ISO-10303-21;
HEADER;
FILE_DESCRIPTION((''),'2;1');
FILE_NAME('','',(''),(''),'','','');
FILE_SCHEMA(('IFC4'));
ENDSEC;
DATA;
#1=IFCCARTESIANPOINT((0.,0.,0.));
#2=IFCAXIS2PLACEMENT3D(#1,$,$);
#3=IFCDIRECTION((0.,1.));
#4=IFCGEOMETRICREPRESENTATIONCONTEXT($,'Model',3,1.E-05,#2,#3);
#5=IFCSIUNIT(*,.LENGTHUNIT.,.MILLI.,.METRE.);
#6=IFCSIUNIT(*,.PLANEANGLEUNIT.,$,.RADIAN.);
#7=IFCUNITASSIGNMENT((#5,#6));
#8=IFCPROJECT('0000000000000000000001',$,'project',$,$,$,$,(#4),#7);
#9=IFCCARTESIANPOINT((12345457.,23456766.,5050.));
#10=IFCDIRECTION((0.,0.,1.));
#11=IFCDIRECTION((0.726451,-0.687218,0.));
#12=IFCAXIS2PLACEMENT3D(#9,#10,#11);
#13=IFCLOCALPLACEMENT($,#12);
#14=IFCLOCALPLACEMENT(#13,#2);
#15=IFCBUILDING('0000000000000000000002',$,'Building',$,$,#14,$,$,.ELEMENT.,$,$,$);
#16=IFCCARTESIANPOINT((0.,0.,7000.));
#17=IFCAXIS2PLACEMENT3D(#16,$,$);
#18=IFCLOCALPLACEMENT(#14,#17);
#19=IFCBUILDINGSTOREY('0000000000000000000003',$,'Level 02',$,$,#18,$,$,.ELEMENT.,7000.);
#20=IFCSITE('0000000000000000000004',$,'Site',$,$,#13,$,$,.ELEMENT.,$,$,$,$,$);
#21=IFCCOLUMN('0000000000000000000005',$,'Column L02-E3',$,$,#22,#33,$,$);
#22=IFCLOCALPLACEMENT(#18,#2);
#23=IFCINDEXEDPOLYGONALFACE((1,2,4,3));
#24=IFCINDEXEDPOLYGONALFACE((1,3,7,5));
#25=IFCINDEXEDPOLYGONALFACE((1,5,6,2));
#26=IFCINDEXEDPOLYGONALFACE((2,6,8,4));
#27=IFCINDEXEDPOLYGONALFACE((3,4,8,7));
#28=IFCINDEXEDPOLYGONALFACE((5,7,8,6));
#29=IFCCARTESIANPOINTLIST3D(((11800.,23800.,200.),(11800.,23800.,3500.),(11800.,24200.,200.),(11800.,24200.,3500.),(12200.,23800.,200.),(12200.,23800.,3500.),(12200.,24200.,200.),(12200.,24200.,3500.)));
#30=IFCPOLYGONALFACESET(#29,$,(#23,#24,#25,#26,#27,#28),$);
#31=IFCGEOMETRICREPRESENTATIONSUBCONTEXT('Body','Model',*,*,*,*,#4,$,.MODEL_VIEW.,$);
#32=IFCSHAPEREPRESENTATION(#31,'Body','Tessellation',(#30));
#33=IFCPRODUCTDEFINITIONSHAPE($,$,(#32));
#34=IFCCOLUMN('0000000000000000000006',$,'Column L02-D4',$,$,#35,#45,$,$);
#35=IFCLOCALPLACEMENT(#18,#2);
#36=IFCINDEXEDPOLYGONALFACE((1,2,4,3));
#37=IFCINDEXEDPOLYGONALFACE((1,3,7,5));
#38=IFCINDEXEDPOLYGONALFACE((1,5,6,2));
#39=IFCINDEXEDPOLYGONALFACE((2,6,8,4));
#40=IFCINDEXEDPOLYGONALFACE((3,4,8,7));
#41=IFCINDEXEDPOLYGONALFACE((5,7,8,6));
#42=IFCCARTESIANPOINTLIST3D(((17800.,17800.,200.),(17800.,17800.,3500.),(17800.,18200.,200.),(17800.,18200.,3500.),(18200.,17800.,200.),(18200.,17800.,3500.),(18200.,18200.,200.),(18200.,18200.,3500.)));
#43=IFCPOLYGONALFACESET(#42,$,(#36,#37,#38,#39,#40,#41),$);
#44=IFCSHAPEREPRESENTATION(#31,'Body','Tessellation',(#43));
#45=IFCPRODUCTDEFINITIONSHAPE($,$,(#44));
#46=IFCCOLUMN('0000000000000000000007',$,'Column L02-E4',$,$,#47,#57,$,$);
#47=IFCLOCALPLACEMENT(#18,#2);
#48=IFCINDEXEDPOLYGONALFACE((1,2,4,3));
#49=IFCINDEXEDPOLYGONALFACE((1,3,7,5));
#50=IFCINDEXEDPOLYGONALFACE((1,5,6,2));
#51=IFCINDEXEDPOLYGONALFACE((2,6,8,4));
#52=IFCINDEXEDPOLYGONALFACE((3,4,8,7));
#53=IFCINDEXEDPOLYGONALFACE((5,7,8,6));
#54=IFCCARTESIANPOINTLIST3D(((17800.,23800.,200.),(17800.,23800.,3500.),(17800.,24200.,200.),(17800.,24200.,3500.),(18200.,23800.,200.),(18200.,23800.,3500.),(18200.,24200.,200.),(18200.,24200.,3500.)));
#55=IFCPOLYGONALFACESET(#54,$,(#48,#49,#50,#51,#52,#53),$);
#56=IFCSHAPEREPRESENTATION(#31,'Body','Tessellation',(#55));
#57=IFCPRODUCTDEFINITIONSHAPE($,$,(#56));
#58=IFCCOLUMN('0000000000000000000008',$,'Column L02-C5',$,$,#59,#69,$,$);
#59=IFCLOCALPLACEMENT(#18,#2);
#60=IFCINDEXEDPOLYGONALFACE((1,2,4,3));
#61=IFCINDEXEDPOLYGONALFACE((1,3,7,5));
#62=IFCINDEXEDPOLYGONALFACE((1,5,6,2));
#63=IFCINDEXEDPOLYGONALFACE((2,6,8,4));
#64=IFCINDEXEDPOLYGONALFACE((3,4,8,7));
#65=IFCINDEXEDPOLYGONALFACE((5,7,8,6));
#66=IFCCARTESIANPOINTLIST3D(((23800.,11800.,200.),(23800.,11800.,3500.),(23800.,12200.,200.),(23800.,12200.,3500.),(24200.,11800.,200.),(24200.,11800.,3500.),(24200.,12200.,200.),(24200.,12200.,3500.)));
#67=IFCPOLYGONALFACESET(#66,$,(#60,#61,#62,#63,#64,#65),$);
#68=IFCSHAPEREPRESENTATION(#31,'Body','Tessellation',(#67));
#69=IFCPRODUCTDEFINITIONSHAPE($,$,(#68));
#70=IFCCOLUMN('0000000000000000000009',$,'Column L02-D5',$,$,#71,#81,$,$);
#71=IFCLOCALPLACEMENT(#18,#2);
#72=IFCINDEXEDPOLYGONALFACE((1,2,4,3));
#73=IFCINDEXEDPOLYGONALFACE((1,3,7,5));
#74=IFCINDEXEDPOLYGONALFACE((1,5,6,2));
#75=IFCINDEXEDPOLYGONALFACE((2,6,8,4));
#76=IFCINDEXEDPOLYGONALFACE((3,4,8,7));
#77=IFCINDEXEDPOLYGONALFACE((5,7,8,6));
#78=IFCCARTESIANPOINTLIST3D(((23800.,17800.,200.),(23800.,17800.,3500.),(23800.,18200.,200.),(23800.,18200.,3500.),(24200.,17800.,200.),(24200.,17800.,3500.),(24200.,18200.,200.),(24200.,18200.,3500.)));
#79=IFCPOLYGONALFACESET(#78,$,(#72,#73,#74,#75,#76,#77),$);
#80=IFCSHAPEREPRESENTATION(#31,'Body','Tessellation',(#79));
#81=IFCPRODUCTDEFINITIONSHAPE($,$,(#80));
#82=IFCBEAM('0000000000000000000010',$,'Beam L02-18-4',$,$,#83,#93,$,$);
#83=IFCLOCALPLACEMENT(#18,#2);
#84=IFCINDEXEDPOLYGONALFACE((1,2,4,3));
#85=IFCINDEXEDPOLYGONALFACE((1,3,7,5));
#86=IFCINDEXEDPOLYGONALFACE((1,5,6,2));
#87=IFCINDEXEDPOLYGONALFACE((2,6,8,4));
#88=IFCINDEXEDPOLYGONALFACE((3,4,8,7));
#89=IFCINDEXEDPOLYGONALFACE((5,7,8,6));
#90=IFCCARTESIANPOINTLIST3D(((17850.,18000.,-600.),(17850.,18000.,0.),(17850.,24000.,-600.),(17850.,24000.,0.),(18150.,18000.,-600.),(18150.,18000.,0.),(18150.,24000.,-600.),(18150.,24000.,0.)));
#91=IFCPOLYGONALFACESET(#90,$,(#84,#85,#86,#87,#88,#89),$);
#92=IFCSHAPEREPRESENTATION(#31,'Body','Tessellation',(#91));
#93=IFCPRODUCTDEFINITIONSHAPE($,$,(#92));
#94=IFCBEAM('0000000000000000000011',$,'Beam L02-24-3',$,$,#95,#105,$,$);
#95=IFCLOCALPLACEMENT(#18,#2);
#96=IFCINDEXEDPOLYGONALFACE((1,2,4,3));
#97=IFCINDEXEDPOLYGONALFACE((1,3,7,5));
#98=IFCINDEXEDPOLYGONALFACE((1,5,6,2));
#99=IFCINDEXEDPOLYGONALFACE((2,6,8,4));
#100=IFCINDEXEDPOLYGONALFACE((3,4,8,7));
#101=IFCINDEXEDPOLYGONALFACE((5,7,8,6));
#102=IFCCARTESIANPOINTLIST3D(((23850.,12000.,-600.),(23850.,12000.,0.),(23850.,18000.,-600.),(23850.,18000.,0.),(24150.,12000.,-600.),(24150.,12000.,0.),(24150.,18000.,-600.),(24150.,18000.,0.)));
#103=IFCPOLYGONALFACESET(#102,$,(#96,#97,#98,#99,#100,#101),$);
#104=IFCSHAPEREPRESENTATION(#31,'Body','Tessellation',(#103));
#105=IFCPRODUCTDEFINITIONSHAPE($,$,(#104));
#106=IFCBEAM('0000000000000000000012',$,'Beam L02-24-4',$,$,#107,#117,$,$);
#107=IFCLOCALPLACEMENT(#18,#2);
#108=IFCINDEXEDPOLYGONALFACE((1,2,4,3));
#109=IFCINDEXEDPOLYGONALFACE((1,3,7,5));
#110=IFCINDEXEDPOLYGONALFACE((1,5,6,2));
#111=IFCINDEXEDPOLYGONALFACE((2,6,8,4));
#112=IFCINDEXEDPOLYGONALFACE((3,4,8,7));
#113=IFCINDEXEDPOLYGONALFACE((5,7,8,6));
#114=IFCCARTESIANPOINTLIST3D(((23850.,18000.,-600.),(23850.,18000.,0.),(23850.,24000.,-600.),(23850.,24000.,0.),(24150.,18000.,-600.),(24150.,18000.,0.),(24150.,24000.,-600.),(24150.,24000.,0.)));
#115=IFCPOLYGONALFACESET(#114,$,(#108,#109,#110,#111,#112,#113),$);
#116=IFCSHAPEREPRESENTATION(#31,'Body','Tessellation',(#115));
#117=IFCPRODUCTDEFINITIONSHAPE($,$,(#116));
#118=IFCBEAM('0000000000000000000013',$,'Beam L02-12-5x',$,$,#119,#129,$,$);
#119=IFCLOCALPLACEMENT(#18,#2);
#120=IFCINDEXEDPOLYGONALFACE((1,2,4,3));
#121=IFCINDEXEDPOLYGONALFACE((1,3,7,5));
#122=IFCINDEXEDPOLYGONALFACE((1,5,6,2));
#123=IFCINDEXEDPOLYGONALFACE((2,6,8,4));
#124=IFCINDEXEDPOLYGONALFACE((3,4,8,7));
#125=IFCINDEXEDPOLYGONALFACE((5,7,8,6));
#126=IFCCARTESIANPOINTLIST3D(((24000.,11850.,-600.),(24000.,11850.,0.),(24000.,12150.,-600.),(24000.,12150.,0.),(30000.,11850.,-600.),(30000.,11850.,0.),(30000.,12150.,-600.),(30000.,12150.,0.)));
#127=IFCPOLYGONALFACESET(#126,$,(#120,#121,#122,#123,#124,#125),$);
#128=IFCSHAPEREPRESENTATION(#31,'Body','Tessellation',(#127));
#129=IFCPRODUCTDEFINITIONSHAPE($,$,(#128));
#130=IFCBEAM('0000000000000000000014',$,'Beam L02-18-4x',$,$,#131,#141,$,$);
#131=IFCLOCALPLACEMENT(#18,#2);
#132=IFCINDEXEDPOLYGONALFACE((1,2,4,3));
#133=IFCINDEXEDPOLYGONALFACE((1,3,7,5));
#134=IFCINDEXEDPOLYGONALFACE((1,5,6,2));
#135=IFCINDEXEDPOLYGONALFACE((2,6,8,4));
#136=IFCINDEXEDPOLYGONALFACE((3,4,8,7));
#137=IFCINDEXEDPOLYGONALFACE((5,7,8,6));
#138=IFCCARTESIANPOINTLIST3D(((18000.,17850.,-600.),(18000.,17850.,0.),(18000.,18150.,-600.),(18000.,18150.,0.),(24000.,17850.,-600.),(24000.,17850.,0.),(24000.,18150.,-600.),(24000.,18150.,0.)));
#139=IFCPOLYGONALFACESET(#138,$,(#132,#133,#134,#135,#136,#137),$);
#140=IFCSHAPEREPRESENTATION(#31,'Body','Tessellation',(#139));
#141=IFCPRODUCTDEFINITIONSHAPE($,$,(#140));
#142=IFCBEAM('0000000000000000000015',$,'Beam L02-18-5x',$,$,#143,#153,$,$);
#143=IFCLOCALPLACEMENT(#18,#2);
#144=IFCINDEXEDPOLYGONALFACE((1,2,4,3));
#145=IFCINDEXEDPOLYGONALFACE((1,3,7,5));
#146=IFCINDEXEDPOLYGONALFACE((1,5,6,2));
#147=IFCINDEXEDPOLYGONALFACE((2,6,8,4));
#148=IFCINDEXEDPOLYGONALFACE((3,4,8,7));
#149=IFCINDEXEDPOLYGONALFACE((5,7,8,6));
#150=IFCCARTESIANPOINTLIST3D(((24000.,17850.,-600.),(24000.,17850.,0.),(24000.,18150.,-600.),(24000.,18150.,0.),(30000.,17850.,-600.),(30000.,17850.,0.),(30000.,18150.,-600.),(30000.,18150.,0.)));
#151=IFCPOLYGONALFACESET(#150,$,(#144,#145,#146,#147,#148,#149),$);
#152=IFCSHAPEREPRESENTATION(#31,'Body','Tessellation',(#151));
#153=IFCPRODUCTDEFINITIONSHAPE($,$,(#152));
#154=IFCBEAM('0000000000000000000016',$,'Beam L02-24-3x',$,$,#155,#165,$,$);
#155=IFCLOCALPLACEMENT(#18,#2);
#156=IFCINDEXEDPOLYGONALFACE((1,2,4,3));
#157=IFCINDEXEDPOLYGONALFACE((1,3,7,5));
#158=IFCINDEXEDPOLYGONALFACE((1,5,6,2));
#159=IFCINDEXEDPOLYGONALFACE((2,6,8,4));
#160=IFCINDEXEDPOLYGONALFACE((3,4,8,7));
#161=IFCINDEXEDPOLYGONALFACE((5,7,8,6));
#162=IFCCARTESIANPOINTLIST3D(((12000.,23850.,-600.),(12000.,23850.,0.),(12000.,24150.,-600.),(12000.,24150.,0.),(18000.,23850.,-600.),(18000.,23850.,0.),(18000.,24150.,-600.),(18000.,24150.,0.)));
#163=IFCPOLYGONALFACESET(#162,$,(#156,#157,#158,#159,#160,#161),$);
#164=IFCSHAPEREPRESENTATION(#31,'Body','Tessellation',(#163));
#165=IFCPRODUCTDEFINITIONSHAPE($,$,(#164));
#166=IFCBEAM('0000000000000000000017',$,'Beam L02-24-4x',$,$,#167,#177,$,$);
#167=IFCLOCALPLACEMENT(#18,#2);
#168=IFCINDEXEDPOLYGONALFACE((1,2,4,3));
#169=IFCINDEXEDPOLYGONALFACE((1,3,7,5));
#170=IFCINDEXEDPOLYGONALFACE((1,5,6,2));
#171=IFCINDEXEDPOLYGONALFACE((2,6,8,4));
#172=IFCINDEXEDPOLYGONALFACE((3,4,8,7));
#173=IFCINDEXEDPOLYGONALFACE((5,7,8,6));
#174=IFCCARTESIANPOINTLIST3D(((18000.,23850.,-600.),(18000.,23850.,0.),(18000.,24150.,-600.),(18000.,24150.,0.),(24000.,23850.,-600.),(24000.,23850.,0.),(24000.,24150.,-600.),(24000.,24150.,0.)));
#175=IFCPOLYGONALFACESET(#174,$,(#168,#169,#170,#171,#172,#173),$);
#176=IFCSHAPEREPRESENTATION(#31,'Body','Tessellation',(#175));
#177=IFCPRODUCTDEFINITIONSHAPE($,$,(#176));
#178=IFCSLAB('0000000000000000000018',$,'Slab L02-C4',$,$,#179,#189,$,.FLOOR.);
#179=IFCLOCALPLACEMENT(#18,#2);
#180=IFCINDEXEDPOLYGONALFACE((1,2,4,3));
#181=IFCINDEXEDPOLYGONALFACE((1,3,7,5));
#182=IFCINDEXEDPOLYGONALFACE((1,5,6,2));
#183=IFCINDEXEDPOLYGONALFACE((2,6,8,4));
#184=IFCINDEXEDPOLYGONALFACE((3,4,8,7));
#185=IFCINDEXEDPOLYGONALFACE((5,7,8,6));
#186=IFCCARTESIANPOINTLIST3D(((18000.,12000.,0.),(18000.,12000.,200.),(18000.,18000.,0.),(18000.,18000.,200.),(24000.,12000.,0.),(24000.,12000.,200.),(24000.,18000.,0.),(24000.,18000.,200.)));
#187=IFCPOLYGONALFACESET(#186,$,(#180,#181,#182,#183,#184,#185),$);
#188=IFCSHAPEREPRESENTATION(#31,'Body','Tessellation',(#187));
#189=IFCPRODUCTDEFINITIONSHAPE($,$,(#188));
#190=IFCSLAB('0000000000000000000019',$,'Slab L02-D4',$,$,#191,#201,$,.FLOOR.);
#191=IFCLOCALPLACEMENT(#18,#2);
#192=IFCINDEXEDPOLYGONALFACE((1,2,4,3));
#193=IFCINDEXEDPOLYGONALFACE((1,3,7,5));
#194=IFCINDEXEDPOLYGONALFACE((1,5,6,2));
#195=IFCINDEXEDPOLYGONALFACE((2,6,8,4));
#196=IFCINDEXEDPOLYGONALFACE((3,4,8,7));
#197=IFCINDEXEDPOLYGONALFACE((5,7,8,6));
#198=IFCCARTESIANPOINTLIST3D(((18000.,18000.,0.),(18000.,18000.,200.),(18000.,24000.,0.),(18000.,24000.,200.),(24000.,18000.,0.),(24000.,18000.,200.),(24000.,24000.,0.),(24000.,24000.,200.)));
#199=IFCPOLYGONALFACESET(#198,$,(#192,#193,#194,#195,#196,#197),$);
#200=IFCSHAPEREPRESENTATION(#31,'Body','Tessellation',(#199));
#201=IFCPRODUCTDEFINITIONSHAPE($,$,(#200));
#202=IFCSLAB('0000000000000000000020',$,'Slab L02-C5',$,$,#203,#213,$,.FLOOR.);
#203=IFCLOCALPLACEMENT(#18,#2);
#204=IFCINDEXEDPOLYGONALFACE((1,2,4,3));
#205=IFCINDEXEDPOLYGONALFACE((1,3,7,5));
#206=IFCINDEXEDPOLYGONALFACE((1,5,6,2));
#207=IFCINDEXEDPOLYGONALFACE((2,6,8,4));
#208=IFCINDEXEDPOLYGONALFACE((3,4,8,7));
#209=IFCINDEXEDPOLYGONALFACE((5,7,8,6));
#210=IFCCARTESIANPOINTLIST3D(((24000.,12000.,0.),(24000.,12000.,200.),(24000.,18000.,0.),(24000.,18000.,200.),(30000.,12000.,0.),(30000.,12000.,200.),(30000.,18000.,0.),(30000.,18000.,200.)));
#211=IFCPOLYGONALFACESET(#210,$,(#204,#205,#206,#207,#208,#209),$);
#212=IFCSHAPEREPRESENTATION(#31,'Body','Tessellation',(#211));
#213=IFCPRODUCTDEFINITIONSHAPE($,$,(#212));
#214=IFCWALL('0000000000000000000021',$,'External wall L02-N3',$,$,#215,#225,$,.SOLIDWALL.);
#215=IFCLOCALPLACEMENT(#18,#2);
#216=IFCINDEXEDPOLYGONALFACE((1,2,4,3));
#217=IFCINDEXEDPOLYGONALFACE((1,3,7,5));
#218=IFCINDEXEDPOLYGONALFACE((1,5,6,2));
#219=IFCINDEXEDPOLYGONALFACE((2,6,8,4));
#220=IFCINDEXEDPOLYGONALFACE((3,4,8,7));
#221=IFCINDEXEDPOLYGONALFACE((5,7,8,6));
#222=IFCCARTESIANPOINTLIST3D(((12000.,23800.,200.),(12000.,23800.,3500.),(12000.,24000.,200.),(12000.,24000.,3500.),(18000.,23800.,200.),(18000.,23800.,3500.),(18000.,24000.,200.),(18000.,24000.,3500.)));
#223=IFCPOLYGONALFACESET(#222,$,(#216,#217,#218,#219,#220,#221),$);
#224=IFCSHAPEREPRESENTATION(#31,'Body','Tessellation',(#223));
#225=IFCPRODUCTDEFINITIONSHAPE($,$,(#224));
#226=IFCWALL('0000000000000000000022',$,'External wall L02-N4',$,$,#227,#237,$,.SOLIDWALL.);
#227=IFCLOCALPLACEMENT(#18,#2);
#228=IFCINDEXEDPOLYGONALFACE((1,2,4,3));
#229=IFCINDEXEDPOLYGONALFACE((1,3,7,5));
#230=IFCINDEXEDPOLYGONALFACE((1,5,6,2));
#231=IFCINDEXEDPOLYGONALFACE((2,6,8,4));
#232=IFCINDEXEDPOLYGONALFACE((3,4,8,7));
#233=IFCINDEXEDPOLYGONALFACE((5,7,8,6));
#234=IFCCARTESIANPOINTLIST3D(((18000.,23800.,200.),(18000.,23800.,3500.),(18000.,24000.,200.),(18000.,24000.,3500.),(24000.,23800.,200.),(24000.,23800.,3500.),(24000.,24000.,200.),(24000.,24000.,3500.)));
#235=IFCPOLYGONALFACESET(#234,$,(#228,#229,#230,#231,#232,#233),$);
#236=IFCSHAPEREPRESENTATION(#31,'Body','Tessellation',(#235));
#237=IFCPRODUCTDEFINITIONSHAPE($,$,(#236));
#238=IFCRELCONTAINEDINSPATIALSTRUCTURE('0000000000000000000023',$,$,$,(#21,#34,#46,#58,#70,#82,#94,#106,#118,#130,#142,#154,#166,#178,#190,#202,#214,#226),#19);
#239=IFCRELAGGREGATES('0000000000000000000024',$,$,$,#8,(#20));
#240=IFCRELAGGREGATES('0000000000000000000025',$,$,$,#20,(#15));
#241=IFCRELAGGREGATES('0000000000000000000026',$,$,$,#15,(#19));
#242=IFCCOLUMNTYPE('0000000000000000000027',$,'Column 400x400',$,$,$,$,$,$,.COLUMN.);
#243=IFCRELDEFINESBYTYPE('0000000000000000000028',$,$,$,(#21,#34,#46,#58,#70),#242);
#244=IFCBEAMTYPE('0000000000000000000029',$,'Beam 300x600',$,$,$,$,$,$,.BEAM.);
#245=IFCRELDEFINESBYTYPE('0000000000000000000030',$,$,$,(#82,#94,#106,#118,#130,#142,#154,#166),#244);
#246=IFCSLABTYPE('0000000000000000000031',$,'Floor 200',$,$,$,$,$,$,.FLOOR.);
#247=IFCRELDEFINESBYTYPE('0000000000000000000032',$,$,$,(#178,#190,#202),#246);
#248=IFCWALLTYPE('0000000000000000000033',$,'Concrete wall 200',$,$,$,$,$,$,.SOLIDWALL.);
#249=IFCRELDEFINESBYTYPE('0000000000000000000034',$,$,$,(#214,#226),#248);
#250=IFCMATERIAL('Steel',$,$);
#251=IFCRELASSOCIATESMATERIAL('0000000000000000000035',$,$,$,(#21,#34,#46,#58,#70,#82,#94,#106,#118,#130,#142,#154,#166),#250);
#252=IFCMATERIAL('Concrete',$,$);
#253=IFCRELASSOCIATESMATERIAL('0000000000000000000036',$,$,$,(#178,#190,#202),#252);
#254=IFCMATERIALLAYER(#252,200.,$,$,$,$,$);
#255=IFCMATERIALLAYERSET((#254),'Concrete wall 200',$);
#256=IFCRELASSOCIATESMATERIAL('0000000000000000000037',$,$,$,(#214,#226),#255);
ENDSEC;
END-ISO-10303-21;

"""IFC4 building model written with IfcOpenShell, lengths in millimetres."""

from ifc_helpers import new_model, si_unit, direction, frame, origin, place, context, subcontext, project, spatial, rectangle, extrude, material, layer, layer_set, layer_usage, type_object, element, save


model = new_model("IFC4")

# Units and contexts
model_context = context("Model", 3, precision=1e-05, world=origin(), true_north=direction((0.0, 1.0)))
body_context = subcontext(model_context, "Body", "Model", "MODEL_VIEW")
ifc_project = project(units=[si_unit("LENGTHUNIT", "METRE", prefix="MILLI"), si_unit("PLANEANGLEUNIT", "RADIAN")], contexts=[model_context])

# Site, building, storey
site_placement = place(None, frame((12345457.0, 23456766.0, 5050.0), z_axis=(0.0, 0.0, 1.0), x_axis=(0.726451, -0.687218, 0.0)))
site = spatial("IfcSite", under=ifc_project, at=site_placement, Name="Site", CompositionType="ELEMENT")
building_placement = place(site_placement, origin())
building = spatial("IfcBuilding", under=site, at=building_placement, Name="Building", CompositionType="ELEMENT")
storey_placement = place(building_placement, frame((0.0, 0.0, 7000.0)))
storey = spatial("IfcBuildingStorey", under=building, at=storey_placement, Name="Level 02", CompositionType="ELEMENT", Elevation=7000.0)

# Columns
ifc_material_1 = material(Name="Steel")
column_type = type_object("IfcColumnType", Name="Column 400x400", PredefinedType="COLUMN")
for number, where, name in (
    (1, (11800.0, 23800.0, 200.0), "Column L02-E3"),
    (2, (17800.0, 17800.0, 200.0), "Column L02-D4"),
    (3, (17800.0, 23800.0, 200.0), "Column L02-E4"),
    (4, (23800.0, 11800.0, 200.0), "Column L02-C5"),
    (5, (23800.0, 17800.0, 200.0), "Column L02-D5"),
):
    element("IfcColumn", number, at=place(storey_placement, frame(where)), inside=storey, type_object=column_type, material=ifc_material_1, Name=name, context=body_context, shape_type="SweptSolid", body=[
        extrude(rectangle(XDim=400.0, YDim=400.0), frame((200.0, 200.0, 0.0)), (0.0, 0.0, 1.0), 3300.0),
    ])

# Beams
beam_type = type_object("IfcBeamType", Name="Beam 300x600", PredefinedType="BEAM")
for number, where, name in (
    (6, (17850.0, 18000.0, -600.0), "Beam L02-18-4"),
    (7, (23850.0, 12000.0, -600.0), "Beam L02-24-3"),
    (8, (23850.0, 18000.0, -600.0), "Beam L02-24-4"),
):
    element("IfcBeam", number, at=place(storey_placement, frame(where)), inside=storey, type_object=beam_type, material=ifc_material_1, Name=name, context=body_context, shape_type="SweptSolid", body=[
        extrude(rectangle(XDim=300.0, YDim=6000.0), frame((150.0, 3000.0, 0.0)), (0.0, 0.0, 1.0), 600.0),
    ])
for number, where, name in (
    (9, (24000.0, 11850.0, -600.0), "Beam L02-12-5x"),
    (10, (18000.0, 17850.0, -600.0), "Beam L02-18-4x"),
    (11, (24000.0, 17850.0, -600.0), "Beam L02-18-5x"),
    (12, (12000.0, 23850.0, -600.0), "Beam L02-24-3x"),
    (13, (18000.0, 23850.0, -600.0), "Beam L02-24-4x"),
):
    element("IfcBeam", number, at=place(storey_placement, frame(where)), inside=storey, type_object=beam_type, material=ifc_material_1, Name=name, context=body_context, shape_type="SweptSolid", body=[
        extrude(rectangle(XDim=6000.0, YDim=300.0), frame((3000.0, 150.0, 0.0)), (0.0, 0.0, 1.0), 600.0),
    ])

# Slabs
ifc_material_2 = material(Name="Concrete")
slab_type = type_object("IfcSlabType", Name="Floor 200", PredefinedType="FLOOR")
for number, where, name in (
    (14, (18000.0, 12000.0, 0.0), "Slab L02-C4"),
    (15, (18000.0, 18000.0, 0.0), "Slab L02-D4"),
    (16, (24000.0, 12000.0, 0.0), "Slab L02-C5"),
):
    element("IfcSlab", number, at=place(storey_placement, frame(where)), inside=storey, type_object=slab_type, material=ifc_material_2, Name=name, PredefinedType="FLOOR", context=body_context, shape_type="SweptSolid", body=[
        extrude(rectangle(XDim=6000.0, YDim=6000.0), frame((3000.0, 3000.0, 0.0)), (0.0, 0.0, 1.0), 200.0),
    ])

# Walls
ifc_layer_1 = layer(ifc_material_2, 200.0)
ifc_layer_set_1 = layer_set([ifc_layer_1], Name="Concrete wall 200")
ifc_layer_usage_1 = layer_usage(ifc_layer_set_1, "AXIS2", "POSITIVE", 0.0)
wall_type_1 = type_object("IfcWallType", Name="Concrete wall 200", PredefinedType="SOLIDWALL")
for number, where, name in (
    (17, (12000.0, 23800.0, 200.0), "External wall L02-N3"),
    (18, (18000.0, 23800.0, 200.0), "External wall L02-N4"),
):
    element("IfcWall", number, at=place(storey_placement, frame(where)), inside=storey, type_object=wall_type_1, material=ifc_layer_usage_1, Name=name, PredefinedType="SOLIDWALL", context=body_context, shape_type="SweptSolid", body=[
        extrude(rectangle(XDim=6000.0, YDim=200.0), frame((3000.0, 100.0, 0.0)), (0.0, 0.0, 1.0), 3300.0),
    ])

save(model, "model.ifc")
